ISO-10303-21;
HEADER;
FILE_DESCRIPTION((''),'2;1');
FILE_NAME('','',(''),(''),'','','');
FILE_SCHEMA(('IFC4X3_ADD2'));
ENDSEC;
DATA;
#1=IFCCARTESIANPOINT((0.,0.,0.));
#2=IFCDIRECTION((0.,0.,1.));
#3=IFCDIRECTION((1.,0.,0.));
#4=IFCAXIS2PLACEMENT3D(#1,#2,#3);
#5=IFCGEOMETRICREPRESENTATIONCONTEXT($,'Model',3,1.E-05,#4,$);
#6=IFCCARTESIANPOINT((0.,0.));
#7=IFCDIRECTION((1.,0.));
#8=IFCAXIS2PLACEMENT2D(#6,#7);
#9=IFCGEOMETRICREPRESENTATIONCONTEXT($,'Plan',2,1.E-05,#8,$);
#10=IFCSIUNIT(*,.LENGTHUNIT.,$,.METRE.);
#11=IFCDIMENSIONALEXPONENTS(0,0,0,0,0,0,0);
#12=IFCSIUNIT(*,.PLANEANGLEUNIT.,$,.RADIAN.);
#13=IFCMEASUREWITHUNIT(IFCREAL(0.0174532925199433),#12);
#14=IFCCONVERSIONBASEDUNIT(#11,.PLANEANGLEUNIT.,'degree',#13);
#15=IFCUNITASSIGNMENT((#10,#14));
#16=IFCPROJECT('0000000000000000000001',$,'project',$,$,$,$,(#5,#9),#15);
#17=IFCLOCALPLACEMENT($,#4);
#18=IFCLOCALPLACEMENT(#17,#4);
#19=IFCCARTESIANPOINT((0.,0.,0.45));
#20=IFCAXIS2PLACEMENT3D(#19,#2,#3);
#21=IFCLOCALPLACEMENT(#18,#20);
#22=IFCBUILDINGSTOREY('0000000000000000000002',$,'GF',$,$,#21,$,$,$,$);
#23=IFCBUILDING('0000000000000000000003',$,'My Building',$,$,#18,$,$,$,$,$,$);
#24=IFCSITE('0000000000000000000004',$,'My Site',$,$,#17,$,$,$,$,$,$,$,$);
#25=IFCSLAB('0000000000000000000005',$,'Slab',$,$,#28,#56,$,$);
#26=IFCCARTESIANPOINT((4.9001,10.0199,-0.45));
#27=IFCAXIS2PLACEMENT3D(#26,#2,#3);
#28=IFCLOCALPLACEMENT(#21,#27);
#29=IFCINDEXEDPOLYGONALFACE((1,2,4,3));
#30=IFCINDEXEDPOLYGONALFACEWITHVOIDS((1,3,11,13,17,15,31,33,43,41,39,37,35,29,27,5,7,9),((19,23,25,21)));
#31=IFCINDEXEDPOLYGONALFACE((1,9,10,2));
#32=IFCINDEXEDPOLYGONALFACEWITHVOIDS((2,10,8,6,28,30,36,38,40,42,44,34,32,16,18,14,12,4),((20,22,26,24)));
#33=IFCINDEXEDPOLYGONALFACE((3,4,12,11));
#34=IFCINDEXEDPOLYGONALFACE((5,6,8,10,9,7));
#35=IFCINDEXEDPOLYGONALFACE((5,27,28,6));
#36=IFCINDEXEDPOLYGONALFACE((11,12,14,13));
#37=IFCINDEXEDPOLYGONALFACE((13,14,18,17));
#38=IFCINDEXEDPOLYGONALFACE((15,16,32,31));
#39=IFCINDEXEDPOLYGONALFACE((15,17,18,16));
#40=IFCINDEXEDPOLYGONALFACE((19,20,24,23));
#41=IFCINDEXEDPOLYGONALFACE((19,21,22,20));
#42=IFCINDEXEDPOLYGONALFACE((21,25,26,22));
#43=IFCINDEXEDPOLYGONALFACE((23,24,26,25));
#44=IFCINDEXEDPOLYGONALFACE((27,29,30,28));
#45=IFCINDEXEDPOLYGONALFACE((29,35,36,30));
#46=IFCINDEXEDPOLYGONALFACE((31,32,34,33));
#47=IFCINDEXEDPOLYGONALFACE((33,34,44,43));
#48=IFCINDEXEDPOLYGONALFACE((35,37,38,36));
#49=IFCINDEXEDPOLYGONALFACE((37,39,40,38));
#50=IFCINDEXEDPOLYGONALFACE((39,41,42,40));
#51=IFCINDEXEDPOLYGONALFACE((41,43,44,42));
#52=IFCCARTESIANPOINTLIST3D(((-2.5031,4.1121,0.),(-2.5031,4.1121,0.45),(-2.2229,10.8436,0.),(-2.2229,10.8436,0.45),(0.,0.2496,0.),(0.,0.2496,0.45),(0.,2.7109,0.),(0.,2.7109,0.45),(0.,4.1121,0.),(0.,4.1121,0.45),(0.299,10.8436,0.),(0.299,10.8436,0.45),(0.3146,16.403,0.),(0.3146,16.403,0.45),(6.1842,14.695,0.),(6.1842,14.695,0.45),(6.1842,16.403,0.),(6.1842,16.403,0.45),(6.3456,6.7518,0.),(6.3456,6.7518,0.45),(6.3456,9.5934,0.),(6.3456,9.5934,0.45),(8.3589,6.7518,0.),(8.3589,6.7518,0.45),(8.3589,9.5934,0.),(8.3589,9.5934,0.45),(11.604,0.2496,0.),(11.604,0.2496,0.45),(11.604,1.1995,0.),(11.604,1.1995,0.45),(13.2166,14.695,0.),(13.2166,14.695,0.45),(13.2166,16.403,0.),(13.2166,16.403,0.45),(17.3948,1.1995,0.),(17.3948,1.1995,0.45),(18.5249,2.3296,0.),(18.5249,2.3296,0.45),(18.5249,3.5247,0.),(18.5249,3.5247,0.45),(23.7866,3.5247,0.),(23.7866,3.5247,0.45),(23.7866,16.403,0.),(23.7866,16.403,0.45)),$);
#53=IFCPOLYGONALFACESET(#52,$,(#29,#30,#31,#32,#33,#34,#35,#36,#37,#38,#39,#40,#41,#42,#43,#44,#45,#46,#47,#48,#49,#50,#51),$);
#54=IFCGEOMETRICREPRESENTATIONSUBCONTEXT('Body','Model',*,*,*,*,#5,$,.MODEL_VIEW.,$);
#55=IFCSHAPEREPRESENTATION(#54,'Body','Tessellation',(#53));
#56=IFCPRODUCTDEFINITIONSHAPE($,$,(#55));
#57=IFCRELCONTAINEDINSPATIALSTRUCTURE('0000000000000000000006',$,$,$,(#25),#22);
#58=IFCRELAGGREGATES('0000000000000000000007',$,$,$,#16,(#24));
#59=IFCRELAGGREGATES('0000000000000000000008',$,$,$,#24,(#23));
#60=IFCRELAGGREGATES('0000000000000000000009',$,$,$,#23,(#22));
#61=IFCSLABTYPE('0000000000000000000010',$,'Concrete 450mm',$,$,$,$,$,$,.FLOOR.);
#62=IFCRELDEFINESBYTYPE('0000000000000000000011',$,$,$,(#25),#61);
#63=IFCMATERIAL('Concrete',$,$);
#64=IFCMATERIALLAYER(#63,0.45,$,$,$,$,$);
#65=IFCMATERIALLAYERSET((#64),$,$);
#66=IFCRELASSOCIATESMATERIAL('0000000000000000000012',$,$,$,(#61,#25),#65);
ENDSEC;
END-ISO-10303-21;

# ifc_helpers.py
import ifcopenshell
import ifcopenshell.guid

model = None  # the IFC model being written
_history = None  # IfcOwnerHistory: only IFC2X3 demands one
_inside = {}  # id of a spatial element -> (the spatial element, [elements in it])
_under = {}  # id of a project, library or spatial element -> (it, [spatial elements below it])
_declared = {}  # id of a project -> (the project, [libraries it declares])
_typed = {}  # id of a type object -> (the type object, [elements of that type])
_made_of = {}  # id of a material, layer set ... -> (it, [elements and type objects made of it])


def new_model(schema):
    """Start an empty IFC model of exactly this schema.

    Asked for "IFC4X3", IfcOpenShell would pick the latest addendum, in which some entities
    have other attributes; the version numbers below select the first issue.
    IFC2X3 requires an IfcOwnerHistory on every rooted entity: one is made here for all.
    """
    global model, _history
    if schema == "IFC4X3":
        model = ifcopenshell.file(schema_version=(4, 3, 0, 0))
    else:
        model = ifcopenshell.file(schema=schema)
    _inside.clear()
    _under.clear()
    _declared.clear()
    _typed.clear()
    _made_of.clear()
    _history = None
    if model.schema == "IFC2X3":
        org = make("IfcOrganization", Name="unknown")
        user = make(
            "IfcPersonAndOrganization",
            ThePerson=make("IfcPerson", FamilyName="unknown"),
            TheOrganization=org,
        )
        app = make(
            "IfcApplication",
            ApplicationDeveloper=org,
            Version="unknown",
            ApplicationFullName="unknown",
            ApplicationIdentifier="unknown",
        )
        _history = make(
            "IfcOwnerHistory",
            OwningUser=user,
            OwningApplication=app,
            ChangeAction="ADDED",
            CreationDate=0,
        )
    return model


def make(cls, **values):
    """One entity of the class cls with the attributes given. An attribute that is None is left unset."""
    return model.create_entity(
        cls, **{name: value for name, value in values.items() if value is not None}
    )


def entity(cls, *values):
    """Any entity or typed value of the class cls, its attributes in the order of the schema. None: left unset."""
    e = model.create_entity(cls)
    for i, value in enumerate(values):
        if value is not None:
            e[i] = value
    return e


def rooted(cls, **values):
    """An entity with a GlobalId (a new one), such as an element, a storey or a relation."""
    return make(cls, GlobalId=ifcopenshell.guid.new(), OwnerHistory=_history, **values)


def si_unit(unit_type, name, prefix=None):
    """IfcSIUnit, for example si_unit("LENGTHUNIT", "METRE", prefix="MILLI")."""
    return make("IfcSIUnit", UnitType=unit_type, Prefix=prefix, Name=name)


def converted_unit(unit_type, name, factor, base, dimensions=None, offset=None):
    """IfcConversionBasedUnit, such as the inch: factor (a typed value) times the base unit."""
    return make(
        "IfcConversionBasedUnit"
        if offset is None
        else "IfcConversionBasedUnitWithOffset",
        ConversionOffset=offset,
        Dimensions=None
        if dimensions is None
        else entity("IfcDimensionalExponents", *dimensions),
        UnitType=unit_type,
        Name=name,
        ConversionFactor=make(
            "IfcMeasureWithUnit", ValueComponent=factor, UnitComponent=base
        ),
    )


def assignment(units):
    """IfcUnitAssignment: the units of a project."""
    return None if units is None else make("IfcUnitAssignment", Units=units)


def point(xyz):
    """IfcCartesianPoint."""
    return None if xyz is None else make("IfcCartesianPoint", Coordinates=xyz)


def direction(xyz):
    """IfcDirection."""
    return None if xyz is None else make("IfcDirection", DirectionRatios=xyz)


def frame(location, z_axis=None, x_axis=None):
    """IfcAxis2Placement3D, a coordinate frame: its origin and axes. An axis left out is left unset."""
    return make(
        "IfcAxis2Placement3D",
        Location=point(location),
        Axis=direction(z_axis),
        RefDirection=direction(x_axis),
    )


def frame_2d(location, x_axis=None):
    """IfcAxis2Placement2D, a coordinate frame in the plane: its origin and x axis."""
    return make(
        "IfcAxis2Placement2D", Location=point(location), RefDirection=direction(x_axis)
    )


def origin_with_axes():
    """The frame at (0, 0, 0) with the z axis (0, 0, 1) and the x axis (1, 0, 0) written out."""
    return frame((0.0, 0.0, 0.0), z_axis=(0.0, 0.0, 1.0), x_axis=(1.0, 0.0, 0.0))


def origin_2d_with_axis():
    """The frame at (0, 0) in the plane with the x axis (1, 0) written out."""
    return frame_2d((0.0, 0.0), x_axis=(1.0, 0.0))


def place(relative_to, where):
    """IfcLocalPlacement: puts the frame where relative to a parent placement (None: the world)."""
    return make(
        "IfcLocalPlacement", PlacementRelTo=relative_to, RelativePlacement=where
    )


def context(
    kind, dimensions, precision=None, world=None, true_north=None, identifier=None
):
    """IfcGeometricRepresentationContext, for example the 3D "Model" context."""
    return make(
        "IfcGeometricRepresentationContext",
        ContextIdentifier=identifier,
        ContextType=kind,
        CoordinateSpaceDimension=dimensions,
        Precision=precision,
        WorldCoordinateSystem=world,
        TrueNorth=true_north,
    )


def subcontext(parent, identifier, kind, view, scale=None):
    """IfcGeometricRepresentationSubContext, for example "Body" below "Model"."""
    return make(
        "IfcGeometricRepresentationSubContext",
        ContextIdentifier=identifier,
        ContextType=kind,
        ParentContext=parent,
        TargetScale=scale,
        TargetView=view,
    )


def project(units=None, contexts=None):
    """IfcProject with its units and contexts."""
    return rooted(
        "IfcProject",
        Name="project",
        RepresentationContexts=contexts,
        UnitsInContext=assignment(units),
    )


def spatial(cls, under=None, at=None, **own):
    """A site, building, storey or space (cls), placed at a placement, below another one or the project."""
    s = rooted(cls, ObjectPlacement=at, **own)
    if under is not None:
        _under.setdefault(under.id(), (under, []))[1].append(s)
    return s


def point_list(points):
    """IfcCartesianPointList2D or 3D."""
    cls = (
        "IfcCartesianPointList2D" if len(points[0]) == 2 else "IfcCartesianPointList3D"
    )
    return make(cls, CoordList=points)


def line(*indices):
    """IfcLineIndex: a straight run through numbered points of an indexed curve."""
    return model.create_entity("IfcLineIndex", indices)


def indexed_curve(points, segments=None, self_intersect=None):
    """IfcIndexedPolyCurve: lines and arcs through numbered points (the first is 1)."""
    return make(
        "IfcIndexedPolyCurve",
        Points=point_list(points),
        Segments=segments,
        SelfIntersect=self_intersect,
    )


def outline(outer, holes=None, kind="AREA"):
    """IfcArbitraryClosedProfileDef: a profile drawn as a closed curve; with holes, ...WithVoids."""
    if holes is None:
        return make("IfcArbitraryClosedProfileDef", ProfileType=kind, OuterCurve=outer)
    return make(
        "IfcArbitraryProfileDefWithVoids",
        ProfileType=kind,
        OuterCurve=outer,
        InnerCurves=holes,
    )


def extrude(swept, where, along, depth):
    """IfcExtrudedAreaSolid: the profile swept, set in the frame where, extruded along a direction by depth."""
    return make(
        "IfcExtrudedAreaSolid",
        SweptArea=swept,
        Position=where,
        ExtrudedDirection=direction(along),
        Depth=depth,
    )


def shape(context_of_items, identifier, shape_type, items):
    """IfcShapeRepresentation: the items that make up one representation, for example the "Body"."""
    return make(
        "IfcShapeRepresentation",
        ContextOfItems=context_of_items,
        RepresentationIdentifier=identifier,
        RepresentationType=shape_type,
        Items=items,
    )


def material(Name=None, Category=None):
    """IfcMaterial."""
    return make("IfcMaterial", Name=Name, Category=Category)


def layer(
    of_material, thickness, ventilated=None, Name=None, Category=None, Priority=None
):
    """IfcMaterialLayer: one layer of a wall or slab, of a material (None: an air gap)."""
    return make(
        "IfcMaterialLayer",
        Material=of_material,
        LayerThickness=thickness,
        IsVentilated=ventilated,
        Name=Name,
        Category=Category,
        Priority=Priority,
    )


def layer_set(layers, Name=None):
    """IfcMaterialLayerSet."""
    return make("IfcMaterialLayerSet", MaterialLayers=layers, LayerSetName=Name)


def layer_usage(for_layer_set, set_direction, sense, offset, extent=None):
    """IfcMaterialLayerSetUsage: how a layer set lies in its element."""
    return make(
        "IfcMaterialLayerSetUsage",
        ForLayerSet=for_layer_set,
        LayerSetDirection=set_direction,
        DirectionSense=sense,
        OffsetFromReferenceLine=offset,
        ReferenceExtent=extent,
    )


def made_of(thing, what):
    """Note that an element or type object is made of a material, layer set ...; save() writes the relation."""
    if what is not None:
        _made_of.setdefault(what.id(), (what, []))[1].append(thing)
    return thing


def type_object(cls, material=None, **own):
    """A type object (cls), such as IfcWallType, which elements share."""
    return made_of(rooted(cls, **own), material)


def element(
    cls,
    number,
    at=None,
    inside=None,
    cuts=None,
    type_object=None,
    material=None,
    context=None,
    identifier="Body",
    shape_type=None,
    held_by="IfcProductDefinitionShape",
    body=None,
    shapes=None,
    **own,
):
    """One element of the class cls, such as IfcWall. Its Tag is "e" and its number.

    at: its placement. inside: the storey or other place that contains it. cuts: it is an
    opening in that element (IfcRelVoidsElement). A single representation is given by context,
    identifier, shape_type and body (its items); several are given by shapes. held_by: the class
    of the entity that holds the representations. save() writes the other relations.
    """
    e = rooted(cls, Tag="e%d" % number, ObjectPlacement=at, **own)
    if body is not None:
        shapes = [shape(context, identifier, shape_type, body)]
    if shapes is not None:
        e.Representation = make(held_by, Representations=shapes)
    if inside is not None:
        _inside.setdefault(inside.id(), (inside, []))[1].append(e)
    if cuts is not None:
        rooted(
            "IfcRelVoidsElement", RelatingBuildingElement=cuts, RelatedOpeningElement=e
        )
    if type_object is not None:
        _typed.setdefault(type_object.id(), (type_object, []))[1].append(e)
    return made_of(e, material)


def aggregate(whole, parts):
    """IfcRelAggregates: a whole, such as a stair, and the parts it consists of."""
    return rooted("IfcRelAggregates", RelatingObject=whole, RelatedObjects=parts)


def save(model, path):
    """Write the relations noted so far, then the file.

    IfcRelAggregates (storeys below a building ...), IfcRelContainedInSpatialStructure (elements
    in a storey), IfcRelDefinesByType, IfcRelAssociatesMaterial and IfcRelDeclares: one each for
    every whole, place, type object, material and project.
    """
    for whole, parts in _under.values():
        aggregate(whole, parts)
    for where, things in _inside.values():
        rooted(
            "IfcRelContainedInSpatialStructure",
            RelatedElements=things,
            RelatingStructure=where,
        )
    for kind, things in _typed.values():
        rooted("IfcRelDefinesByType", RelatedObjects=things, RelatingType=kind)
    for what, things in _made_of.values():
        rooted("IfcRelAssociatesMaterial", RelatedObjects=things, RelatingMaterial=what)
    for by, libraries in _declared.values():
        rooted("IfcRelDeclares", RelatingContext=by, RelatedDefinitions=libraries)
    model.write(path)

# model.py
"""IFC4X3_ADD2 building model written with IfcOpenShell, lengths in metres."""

from ifc_helpers import new_model, entity, si_unit, converted_unit, frame, origin_with_axes, origin_2d_with_axis, place, context, subcontext, project, spatial, line, indexed_curve, outline, extrude, material, layer, layer_set, layer_usage, type_object, element, save


model = new_model("IFC4X3_ADD2")

# Units and contexts
model_context = context("Model", 3, precision=1e-05, world=origin_with_axes())
plan_context = context("Plan", 2, precision=1e-05, world=origin_2d_with_axis())
body_context_1 = subcontext(model_context, "Body", "Model", "MODEL_VIEW")
ifc_project = project(units=[si_unit("LENGTHUNIT", "METRE"), converted_unit("PLANEANGLEUNIT", "degree", entity("IfcReal", 0.0174532925199433), si_unit("PLANEANGLEUNIT", "RADIAN"), dimensions=[0, 0, 0, 0, 0, 0, 0])], contexts=[model_context, plan_context])

# Site, building, storey
site_placement = place(None, origin_with_axes())
site = spatial("IfcSite", under=ifc_project, at=site_placement, Name="My Site")
building_placement = place(site_placement, origin_with_axes())
building = spatial("IfcBuilding", under=site, at=building_placement, Name="My Building")
storey_placement = place(building_placement, frame((0.0, 0.0, 0.45), z_axis=(0.0, 0.0, 1.0), x_axis=(1.0, 0.0, 0.0)))
storey = spatial("IfcBuildingStorey", under=building, at=storey_placement, Name="GF")

# Slab
ifc_material_1 = material(Name="Concrete")
ifc_layer_1 = layer(ifc_material_1, 0.45)
ifc_layer_set_1 = layer_set([ifc_layer_1])
ifc_layer_usage_1 = layer_usage(ifc_layer_set_1, "AXIS3", "POSITIVE", 0.0)
slab_type = type_object("IfcSlabType", Name="Concrete 450mm", PredefinedType="FLOOR", material=ifc_layer_set_1)
slab_placement = place(storey_placement, frame((4.9001, 10.0199, -0.45), z_axis=(0.0, 0.0, 1.0), x_axis=(1.0, 0.0, 0.0)))
element("IfcSlab", 1, at=slab_placement, inside=storey, type_object=slab_type, material=ifc_layer_usage_1, Name="Slab", context=body_context_1, shape_type="SweptSolid", body=[
    extrude(outline(indexed_curve([(23.7866, 16.403), (13.2166, 16.403), (13.2166, 14.695), (6.1842, 14.695), (6.1842, 16.403), (0.3146, 16.403), (0.299, 10.8436), (-2.2229, 10.8436), (-2.5031, 4.1121), (0.0, 4.1121), (0.0, 2.7109), (0.0, 0.2496), (11.604, 0.2496), (11.604, 1.1995), (17.3948, 1.1995), (18.5249, 2.3296), (18.5249, 3.5247), (23.7866, 3.5247), (8.3589, 6.7518), (6.3456, 6.7518), (6.3456, 9.5934), (8.3589, 9.5934)], segments=[line(15, 14), line(14, 13), line(13, 12), line(12, 11), line(11, 10), line(10, 9), line(9, 8), line(8, 7), line(7, 6), line(6, 5), line(5, 4), line(4, 3), line(3, 2), line(2, 1), line(1, 18), line(18, 17), line(17, 16), line(16, 15)], self_intersect=False), holes=[indexed_curve([(23.7866, 16.403), (13.2166, 16.403), (13.2166, 14.695), (6.1842, 14.695), (6.1842, 16.403), (0.3146, 16.403), (0.299, 10.8436), (-2.2229, 10.8436), (-2.5031, 4.1121), (0.0, 4.1121), (0.0, 2.7109), (0.0, 0.2496), (11.604, 0.2496), (11.604, 1.1995), (17.3948, 1.1995), (18.5249, 2.3296), (18.5249, 3.5247), (23.7866, 3.5247), (8.3589, 6.7518), (6.3456, 6.7518), (6.3456, 9.5934), (8.3589, 9.5934)], segments=[line(22, 21), line(21, 20), line(20, 19), line(19, 22)], self_intersect=False)]), None, (0.0, 0.0, 1.0), 0.45),
])

save(model, "model.ifc")
